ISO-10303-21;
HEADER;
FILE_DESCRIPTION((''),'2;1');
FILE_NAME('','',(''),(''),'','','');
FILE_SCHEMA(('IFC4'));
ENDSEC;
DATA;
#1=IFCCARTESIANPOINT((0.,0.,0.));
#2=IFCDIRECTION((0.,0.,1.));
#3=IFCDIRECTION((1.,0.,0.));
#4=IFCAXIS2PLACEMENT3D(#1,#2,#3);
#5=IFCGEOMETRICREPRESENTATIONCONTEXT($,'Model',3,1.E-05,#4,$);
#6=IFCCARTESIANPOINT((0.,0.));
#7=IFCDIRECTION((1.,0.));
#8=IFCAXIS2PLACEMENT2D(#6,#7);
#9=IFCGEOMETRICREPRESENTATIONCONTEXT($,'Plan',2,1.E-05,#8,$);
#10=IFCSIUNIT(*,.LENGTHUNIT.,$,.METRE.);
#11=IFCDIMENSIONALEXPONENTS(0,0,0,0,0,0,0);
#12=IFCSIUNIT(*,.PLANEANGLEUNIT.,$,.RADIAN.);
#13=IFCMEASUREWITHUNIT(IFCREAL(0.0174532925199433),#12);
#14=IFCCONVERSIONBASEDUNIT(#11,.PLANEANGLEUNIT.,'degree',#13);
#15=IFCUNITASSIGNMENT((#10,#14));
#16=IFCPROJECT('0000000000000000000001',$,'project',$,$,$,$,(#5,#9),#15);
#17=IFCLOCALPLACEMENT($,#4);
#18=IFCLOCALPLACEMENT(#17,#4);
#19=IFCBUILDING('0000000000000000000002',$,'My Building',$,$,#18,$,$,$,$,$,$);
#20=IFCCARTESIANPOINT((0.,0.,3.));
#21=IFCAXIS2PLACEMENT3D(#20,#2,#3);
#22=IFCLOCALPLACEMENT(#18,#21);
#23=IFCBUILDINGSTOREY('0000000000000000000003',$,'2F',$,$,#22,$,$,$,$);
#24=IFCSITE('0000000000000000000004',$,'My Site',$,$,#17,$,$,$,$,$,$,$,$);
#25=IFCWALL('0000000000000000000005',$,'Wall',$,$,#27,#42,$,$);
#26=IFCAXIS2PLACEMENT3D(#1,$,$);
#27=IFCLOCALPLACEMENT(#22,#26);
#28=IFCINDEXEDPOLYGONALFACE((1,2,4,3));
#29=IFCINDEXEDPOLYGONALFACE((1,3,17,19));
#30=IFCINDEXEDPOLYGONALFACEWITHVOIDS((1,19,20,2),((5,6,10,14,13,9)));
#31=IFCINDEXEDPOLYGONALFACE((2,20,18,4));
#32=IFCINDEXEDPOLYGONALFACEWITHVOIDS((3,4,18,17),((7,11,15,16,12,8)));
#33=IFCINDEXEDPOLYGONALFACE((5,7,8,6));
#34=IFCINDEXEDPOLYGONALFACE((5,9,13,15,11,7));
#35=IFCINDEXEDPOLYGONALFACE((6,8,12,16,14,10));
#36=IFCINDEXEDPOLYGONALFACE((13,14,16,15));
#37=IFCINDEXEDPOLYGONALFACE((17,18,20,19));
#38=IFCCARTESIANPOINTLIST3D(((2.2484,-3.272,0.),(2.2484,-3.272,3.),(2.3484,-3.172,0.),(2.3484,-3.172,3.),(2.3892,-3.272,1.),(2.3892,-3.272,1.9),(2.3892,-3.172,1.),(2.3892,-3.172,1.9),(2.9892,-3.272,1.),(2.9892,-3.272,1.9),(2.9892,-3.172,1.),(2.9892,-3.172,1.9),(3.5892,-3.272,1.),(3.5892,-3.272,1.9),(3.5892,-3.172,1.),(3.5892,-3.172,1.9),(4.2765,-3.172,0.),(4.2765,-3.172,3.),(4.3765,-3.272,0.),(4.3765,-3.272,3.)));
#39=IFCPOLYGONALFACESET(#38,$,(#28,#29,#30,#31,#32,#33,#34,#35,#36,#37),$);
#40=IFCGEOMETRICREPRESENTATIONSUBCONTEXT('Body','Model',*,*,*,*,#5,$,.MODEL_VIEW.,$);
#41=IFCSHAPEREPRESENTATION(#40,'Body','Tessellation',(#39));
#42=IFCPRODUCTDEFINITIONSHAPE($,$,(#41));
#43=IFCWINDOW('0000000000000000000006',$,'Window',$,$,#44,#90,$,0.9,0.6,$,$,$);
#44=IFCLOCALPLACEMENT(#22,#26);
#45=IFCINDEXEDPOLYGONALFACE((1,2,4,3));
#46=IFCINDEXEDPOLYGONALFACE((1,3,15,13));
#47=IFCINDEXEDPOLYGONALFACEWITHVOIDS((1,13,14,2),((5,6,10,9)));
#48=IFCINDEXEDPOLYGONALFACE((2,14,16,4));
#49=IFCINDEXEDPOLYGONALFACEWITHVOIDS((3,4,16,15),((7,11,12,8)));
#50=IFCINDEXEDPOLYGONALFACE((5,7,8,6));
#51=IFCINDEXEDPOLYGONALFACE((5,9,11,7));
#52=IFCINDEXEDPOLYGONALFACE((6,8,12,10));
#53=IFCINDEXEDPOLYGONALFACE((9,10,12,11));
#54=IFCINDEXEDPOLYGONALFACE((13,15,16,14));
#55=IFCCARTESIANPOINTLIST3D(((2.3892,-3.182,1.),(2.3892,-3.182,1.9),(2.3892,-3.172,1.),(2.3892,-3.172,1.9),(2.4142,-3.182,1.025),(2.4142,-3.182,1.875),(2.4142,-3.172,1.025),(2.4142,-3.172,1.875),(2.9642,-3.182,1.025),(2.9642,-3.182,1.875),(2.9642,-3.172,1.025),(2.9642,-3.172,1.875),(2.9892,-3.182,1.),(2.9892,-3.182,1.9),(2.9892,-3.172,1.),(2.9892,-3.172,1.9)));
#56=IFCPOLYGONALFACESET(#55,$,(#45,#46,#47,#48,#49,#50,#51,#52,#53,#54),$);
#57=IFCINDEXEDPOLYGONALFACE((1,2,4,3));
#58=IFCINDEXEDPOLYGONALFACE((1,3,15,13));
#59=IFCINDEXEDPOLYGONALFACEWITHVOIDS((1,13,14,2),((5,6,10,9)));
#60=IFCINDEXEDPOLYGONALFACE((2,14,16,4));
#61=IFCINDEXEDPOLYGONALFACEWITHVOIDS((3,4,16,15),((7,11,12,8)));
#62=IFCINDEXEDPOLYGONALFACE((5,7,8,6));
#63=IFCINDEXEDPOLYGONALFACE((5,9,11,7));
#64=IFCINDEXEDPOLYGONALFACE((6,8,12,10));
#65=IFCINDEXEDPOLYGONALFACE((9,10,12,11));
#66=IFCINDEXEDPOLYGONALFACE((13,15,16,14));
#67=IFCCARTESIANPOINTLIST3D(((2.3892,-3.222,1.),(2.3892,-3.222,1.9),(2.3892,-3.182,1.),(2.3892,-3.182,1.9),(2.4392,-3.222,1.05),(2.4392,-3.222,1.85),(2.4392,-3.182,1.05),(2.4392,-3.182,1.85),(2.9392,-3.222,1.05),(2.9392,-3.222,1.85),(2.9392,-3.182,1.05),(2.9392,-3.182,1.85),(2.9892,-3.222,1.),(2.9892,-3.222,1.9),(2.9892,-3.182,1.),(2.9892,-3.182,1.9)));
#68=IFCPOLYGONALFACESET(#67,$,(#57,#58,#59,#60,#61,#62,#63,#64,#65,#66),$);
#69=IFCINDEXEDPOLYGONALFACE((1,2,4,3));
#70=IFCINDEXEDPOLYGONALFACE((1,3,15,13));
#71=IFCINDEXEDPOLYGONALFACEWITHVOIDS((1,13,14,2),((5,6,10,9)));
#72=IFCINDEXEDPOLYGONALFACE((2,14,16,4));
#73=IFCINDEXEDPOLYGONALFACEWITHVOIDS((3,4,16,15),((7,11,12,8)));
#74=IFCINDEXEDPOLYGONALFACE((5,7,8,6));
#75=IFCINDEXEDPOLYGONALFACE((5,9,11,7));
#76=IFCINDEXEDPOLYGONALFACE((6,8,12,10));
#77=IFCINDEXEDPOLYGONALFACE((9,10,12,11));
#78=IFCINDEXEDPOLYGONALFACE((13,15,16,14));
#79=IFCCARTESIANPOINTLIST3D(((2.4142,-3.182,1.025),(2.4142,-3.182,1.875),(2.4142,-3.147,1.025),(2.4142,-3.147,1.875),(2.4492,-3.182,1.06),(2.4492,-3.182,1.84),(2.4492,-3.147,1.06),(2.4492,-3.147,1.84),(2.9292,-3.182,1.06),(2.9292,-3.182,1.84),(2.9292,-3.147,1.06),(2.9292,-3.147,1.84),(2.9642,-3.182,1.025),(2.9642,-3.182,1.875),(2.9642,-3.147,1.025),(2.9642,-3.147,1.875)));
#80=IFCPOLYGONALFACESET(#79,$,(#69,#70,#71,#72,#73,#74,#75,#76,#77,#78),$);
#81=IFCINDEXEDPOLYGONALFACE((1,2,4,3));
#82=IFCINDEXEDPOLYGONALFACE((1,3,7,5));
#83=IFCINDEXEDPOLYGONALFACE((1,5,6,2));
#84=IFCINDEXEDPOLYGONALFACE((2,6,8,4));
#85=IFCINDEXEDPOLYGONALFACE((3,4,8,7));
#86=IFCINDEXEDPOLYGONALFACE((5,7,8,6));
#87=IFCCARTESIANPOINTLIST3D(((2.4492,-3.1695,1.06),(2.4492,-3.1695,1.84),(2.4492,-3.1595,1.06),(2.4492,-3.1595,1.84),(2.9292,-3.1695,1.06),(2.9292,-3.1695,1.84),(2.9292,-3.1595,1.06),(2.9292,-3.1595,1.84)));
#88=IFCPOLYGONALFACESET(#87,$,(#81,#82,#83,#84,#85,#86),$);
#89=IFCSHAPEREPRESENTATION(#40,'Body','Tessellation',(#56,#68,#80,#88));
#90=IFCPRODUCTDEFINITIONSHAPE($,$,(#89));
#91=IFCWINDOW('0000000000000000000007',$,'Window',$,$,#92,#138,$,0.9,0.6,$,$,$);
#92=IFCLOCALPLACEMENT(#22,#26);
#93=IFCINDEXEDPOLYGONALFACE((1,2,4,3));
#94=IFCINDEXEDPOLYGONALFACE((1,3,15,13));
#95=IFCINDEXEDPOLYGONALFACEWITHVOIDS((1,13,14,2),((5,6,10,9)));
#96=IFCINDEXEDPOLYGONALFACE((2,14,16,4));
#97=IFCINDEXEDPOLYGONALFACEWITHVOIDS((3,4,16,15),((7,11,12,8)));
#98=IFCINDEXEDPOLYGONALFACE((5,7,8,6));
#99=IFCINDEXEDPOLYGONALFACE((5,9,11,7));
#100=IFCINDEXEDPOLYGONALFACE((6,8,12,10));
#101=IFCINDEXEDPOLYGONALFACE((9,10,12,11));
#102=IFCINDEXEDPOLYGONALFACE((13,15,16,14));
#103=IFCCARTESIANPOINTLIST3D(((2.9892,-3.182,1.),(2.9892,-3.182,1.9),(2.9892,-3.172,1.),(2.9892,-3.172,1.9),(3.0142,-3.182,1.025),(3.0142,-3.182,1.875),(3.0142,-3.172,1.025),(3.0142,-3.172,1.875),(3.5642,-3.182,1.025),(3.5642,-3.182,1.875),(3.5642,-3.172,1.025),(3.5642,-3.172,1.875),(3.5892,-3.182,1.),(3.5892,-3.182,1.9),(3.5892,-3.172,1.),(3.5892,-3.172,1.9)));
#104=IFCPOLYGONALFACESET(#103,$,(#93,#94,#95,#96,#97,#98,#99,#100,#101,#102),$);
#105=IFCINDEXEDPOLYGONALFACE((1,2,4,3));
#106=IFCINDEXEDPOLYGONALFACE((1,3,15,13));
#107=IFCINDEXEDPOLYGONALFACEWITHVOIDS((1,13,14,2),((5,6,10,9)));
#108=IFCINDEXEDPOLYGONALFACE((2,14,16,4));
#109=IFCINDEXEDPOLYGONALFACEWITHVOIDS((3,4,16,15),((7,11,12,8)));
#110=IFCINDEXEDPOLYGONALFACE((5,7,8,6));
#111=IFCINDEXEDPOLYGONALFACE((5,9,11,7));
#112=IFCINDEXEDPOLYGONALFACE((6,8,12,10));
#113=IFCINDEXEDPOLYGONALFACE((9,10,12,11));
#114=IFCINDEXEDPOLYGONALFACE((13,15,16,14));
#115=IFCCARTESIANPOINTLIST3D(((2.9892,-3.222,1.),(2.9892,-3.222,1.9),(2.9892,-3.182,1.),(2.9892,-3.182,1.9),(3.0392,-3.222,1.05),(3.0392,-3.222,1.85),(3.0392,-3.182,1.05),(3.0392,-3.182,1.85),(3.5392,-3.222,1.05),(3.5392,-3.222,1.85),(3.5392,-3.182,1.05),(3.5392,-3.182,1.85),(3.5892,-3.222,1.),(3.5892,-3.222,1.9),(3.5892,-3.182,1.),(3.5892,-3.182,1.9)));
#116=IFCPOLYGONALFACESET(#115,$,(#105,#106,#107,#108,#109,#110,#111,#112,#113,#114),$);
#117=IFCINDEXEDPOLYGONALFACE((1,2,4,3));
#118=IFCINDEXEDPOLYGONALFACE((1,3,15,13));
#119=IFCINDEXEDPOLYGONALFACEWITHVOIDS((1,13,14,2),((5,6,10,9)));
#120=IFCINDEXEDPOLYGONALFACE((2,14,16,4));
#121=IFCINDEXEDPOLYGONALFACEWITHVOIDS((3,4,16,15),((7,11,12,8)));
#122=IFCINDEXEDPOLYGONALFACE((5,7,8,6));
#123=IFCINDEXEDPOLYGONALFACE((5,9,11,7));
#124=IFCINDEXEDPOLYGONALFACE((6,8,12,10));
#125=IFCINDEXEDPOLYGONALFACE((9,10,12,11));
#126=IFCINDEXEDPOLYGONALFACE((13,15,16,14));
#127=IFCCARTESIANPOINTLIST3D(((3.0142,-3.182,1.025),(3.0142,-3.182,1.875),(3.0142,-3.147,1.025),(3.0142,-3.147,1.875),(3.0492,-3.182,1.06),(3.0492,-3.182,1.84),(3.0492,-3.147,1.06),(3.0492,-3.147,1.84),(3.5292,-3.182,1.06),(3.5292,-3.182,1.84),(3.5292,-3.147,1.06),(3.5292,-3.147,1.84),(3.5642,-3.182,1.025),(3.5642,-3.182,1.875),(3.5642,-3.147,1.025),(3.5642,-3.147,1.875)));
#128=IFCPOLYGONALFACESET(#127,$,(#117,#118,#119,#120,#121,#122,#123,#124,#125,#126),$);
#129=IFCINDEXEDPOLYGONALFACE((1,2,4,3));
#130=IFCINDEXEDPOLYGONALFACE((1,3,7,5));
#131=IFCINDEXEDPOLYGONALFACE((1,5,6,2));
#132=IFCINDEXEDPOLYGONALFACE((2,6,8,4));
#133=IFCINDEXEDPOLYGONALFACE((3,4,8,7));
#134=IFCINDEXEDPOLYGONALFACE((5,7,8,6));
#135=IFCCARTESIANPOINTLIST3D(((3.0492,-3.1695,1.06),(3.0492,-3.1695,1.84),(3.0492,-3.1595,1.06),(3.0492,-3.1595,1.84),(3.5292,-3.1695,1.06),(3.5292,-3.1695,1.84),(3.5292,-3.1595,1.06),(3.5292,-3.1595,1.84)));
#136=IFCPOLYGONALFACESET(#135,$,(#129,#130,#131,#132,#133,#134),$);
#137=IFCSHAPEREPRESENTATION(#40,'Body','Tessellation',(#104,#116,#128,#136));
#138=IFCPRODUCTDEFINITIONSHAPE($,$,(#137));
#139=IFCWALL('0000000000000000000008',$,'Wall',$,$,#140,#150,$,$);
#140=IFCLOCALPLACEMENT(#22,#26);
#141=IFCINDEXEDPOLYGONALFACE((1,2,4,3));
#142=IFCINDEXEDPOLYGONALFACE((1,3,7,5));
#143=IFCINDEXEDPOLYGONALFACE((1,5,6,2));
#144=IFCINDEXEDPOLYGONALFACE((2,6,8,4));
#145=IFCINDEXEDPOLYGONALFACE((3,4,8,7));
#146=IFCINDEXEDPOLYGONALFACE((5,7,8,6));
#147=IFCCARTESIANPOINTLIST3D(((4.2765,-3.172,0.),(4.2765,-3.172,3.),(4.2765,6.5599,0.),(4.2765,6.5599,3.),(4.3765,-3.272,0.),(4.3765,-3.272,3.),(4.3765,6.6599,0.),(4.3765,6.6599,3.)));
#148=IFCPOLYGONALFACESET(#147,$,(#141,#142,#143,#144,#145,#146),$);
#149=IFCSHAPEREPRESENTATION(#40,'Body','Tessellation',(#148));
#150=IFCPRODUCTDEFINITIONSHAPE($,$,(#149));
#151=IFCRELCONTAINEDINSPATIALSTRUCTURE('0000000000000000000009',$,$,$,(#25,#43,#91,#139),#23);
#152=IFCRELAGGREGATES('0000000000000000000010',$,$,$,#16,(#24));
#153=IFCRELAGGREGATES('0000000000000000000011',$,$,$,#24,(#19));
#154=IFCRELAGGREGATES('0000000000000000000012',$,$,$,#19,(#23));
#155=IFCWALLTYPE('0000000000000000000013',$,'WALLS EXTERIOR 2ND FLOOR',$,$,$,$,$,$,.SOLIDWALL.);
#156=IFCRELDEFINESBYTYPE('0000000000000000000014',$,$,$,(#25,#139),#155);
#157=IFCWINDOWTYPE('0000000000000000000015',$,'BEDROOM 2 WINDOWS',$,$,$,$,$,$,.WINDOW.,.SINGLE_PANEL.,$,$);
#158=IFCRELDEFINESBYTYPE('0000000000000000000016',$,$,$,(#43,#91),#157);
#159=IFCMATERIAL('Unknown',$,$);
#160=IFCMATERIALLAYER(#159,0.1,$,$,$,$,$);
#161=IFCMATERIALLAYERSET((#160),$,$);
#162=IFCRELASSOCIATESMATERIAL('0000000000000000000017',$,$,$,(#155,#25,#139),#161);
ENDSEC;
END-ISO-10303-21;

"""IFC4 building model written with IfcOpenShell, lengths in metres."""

from ifc_helpers import new_model, entity, si_unit, converted_unit, frame, origin_with_axes, origin_2d_with_axis, place, context, subcontext, project, spatial, line, indexed_curve, outline, extrude, shape, source, transform, mapped, material, layer, layer_set, layer_usage, type_object, type_shapes, element, fill, save


model = new_model("IFC4")

# Units and contexts
model_context = context("Model", 3, precision=1e-05, world=origin_with_axes())
plan_context = context("Plan", 2, precision=1e-05, world=origin_2d_with_axis())
body_context_1 = subcontext(model_context, "Body", "Model", "MODEL_VIEW")
body_context_2 = subcontext(plan_context, "Body", "Plan", "PLAN_VIEW")
ifc_project = project(units=[si_unit("LENGTHUNIT", "METRE"), converted_unit("PLANEANGLEUNIT", "degree", entity("IfcReal", 0.0174532925199433), si_unit("PLANEANGLEUNIT", "RADIAN"), dimensions=[0, 0, 0, 0, 0, 0, 0])], contexts=[model_context, plan_context])

# Site, building, storey
site_placement = place(None, origin_with_axes())
site = spatial("IfcSite", under=ifc_project, at=site_placement, Name="My Site")
building_placement = place(site_placement, origin_with_axes())
building = spatial("IfcBuilding", under=site, at=building_placement, Name="My Building")
storey_placement = place(building_placement, frame((0.0, 0.0, 3.0), z_axis=(0.0, 0.0, 1.0), x_axis=(1.0, 0.0, 0.0)))
storey = spatial("IfcBuildingStorey", under=building, at=storey_placement, Name="2F")

# Shared definitions
ifc_material = material(Name="Unknown")

# Shared definitions
ifc_layer_1 = layer(ifc_material, 0.1)
ifc_layer_set_1 = layer_set([ifc_layer_1])
wall_type_1 = type_object("IfcWallType", Name="WALLS EXTERIOR 2ND FLOOR", PredefinedType="SOLIDWALL", material=ifc_layer_set_1)

# Wall, openings, windows
ifc_layer_usage_1 = layer_usage(ifc_layer_set_1, "AXIS2", "POSITIVE", 0.0)
wall_1_placement = place(storey_placement, frame((2.2484, -3.272, 0.0), z_axis=(0.0, 0.0, 1.0), x_axis=(1.0, 0.0, 0.0)))
wall_1 = element("IfcWall", 1, at=wall_1_placement, inside=storey, type_object=wall_type_1, material=ifc_layer_usage_1, Name="Wall", context=body_context_1, shape_type="SweptSolid", body=[
    extrude(outline(indexed_curve([(0.0, 0.0), (0.1, 0.1), (2.0281, 0.1), (2.1281, 0.0)], segments=[line(1, 2, 3, 4, 1)])), origin_with_axes(), (0.0, 0.0, 1.0), 3.0),
])
shared_shape_1 = source(origin_with_axes(), body_context_1, "Body", "SweptSolid", [
    extrude(outline(indexed_curve([(0.0, 0.0), (0.6, 0.0), (0.6, 0.9), (0.0, 0.9)], segments=[line(1, 2, 3, 4, 1)])), frame((0.0, -0.6, 0.0), z_axis=(0.0, -1.0, 0.0), x_axis=(1.0, 0.0, 0.0)), (0.0, 0.0, -1.0), 1.2),
])
opening_1_placement = place(wall_1_placement, frame((0.1408, 0.0, 1.0), z_axis=(0.0, 0.0, 1.0), x_axis=(1.0, 0.0, 0.0)))
opening_1 = element("IfcOpeningElement", 2, at=opening_1_placement, cuts=wall_1, PredefinedType="OPENING", context=body_context_1, shape_type="MappedRepresentation", body=[
    mapped(shared_shape_1, transform((0.0, 0.0, 0.0), x_axis=(1.0, 0.0, 0.0), y_axis=(0.0, 1.0, 0.0), z_axis=(0.0, 0.0, 1.0), scale=1.0)),
])
opening_2_placement = place(wall_1_placement, frame((0.7408, 0.0, 1.0), z_axis=(0.0, 0.0, 1.0), x_axis=(1.0, 0.0, 0.0)))
opening_2 = element("IfcOpeningElement", 3, at=opening_2_placement, cuts=wall_1, PredefinedType="OPENING", context=body_context_1, shape_type="MappedRepresentation", body=[
    mapped(shared_shape_1, transform((0.0, 0.0, 0.0), x_axis=(1.0, 0.0, 0.0), y_axis=(0.0, 1.0, 0.0), z_axis=(0.0, 0.0, 1.0), scale=1.0)),
])
window_type = type_object("IfcWindowType", Name="BEDROOM 2 WINDOWS", PartitioningType="SINGLE_PANEL", PredefinedType="WINDOW")
shared_shape_2 = source(origin_with_axes(), body_context_1, "Body", "SweptSolid", [
    extrude(outline(indexed_curve([(0.0, 0.0), (0.6, 0.0), (0.6, 0.9), (0.0, 0.9)], segments=[line(1, 2, 3, 4, 1)]), holes=[indexed_curve([(0.025, 0.025), (0.575, 0.025), (0.575, 0.875), (0.025, 0.875)], segments=[line(1, 2, 3, 4, 1)])]), frame((0.0, 0.09, 0.0), z_axis=(0.0, -1.0, 0.0), x_axis=(1.0, 0.0, 0.0)), (0.0, 0.0, -1.0), 0.01),
    extrude(outline(indexed_curve([(0.0, 0.0), (0.6, 0.0), (0.6, 0.9), (0.0, 0.9)], segments=[line(1, 2, 3, 4, 1)]), holes=[indexed_curve([(0.05, 0.05), (0.55, 0.05), (0.55, 0.85), (0.05, 0.85)], segments=[line(1, 2, 3, 4, 1)])]), frame((0.0, 0.05, 0.0), z_axis=(0.0, -1.0, 0.0), x_axis=(1.0, 0.0, 0.0)), (0.0, 0.0, -1.0), 0.04),
    extrude(outline(indexed_curve([(0.0, 0.0), (0.55, 0.0), (0.55, 0.85), (0.0, 0.85)], segments=[line(1, 2, 3, 4, 1)]), holes=[indexed_curve([(0.035, 0.035), (0.515, 0.035), (0.515, 0.815), (0.035, 0.815)], segments=[line(1, 2, 3, 4, 1)])]), frame((0.025, 0.09, 0.025), z_axis=(0.0, -1.0, 0.0), x_axis=(1.0, 0.0, 0.0)), (0.0, 0.0, -1.0), 0.035),
    extrude(outline(indexed_curve([(0.035, 0.035), (0.515, 0.035), (0.515, 0.815), (0.035, 0.815)], segments=[line(1, 2, 3, 4, 1)])), frame((0.025, 0.1025, 0.025), z_axis=(0.0, -1.0, 0.0), x_axis=(1.0, 0.0, 0.0)), (0.0, 0.0, -1.0), 0.01),
])
shared_shape_3 = source(origin_with_axes(), body_context_2, "Body", "Curve2D", [
    entity("IfcIndexedPolyCurve", entity("IfcCartesianPointList2D", [[0.05, 0.05], [0.55, 0.05]])),
    entity("IfcIndexedPolyCurve", entity("IfcCartesianPointList2D", [[0.0, 0.1], [0.025, 0.1], [0.025, 0.09], [0.05, 0.09], [0.05, 0.05], [0.0, 0.05]]), [entity("IfcLineIndex", [1, 2, 3, 4, 5, 6, 1])]),
    entity("IfcIndexedPolyCurve", entity("IfcCartesianPointList2D", [[0.6, 0.1], [0.575, 0.1], [0.575, 0.09], [0.55, 0.09], [0.55, 0.05], [0.6, 0.05]]), [entity("IfcLineIndex", [1, 2, 3, 4, 5, 6, 1])]),
    entity("IfcIndexedPolyCurve", entity("IfcCartesianPointList2D", [[0.025, 0.09], [0.06, 0.09], [0.06, 0.125], [0.025, 0.125]]), [entity("IfcLineIndex", [1, 2, 3, 4, 1])]),
    entity("IfcIndexedPolyCurve", entity("IfcCartesianPointList2D", [[0.575, 0.09], [0.54, 0.09], [0.54, 0.125], [0.575, 0.125]]), [entity("IfcLineIndex", [1, 2, 3, 4, 1])]),
    entity("IfcIndexedPolyCurve", entity("IfcCartesianPointList2D", [[0.06, 0.09], [0.54, 0.09]])),
    entity("IfcIndexedPolyCurve", entity("IfcCartesianPointList2D", [[0.06, 0.125], [0.54, 0.125]])),
    entity("IfcIndexedPolyCurve", entity("IfcCartesianPointList2D", [[0.06, 0.1075], [0.54, 0.1075]])),
])
type_shapes(window_type, [shared_shape_2, shared_shape_3])
window_1_placement = place(opening_1_placement, origin_with_axes())
window_1 = element("IfcWindow", 4, at=window_1_placement, inside=storey, type_object=window_type, Name="Window", OverallHeight=0.9, OverallWidth=0.6, shapes=[
    shape(body_context_1, "Body", "MappedRepresentation", [mapped(shared_shape_2, transform((0.0, 0.0, 0.0), x_axis=(1.0, 0.0, 0.0), y_axis=(0.0, 1.0, 0.0), z_axis=(0.0, 0.0, 1.0), scale=1.0))]),
    shape(body_context_2, "Body", "MappedRepresentation", [mapped(shared_shape_3, transform((0.0, 0.0, 0.0), x_axis=(1.0, 0.0, 0.0), y_axis=(0.0, 1.0, 0.0), z_axis=(0.0, 0.0, 1.0), scale=1.0))]),
])
fill(opening_1, window_1)
window_2_placement = place(opening_2_placement, origin_with_axes())
window_2 = element("IfcWindow", 5, at=window_2_placement, inside=storey, type_object=window_type, Name="Window", OverallHeight=0.9, OverallWidth=0.6, shapes=[
    shape(body_context_1, "Body", "MappedRepresentation", [mapped(shared_shape_2, transform((0.0, 0.0, 0.0), x_axis=(1.0, 0.0, 0.0), y_axis=(0.0, 1.0, 0.0), z_axis=(0.0, 0.0, 1.0), scale=1.0))]),
    shape(body_context_2, "Body", "MappedRepresentation", [mapped(shared_shape_3, transform((0.0, 0.0, 0.0), x_axis=(1.0, 0.0, 0.0), y_axis=(0.0, 1.0, 0.0), z_axis=(0.0, 0.0, 1.0), scale=1.0))]),
])
fill(opening_2, window_2)

# Wall
ifc_layer_usage_2 = layer_usage(ifc_layer_set_1, "AXIS2", "POSITIVE", 0.0)
wall_2_placement = place(storey_placement, frame((4.3765, -3.272, 0.0), z_axis=(0.0, 0.0, 1.0), x_axis=(0.0, 1.0, 0.0)))
element("IfcWall", 6, at=wall_2_placement, inside=storey, type_object=wall_type_1, material=ifc_layer_usage_2, Name="Wall", context=body_context_1, shape_type="SweptSolid", body=[
    extrude(outline(indexed_curve([(0.0, 0.0), (0.1, 0.1), (9.8319, 0.1), (9.9319, 0.0)], segments=[line(1, 2, 3, 4, 1)])), origin_with_axes(), (0.0, 0.0, 1.0), 3.0),
])

save(model, "model.ifc")
